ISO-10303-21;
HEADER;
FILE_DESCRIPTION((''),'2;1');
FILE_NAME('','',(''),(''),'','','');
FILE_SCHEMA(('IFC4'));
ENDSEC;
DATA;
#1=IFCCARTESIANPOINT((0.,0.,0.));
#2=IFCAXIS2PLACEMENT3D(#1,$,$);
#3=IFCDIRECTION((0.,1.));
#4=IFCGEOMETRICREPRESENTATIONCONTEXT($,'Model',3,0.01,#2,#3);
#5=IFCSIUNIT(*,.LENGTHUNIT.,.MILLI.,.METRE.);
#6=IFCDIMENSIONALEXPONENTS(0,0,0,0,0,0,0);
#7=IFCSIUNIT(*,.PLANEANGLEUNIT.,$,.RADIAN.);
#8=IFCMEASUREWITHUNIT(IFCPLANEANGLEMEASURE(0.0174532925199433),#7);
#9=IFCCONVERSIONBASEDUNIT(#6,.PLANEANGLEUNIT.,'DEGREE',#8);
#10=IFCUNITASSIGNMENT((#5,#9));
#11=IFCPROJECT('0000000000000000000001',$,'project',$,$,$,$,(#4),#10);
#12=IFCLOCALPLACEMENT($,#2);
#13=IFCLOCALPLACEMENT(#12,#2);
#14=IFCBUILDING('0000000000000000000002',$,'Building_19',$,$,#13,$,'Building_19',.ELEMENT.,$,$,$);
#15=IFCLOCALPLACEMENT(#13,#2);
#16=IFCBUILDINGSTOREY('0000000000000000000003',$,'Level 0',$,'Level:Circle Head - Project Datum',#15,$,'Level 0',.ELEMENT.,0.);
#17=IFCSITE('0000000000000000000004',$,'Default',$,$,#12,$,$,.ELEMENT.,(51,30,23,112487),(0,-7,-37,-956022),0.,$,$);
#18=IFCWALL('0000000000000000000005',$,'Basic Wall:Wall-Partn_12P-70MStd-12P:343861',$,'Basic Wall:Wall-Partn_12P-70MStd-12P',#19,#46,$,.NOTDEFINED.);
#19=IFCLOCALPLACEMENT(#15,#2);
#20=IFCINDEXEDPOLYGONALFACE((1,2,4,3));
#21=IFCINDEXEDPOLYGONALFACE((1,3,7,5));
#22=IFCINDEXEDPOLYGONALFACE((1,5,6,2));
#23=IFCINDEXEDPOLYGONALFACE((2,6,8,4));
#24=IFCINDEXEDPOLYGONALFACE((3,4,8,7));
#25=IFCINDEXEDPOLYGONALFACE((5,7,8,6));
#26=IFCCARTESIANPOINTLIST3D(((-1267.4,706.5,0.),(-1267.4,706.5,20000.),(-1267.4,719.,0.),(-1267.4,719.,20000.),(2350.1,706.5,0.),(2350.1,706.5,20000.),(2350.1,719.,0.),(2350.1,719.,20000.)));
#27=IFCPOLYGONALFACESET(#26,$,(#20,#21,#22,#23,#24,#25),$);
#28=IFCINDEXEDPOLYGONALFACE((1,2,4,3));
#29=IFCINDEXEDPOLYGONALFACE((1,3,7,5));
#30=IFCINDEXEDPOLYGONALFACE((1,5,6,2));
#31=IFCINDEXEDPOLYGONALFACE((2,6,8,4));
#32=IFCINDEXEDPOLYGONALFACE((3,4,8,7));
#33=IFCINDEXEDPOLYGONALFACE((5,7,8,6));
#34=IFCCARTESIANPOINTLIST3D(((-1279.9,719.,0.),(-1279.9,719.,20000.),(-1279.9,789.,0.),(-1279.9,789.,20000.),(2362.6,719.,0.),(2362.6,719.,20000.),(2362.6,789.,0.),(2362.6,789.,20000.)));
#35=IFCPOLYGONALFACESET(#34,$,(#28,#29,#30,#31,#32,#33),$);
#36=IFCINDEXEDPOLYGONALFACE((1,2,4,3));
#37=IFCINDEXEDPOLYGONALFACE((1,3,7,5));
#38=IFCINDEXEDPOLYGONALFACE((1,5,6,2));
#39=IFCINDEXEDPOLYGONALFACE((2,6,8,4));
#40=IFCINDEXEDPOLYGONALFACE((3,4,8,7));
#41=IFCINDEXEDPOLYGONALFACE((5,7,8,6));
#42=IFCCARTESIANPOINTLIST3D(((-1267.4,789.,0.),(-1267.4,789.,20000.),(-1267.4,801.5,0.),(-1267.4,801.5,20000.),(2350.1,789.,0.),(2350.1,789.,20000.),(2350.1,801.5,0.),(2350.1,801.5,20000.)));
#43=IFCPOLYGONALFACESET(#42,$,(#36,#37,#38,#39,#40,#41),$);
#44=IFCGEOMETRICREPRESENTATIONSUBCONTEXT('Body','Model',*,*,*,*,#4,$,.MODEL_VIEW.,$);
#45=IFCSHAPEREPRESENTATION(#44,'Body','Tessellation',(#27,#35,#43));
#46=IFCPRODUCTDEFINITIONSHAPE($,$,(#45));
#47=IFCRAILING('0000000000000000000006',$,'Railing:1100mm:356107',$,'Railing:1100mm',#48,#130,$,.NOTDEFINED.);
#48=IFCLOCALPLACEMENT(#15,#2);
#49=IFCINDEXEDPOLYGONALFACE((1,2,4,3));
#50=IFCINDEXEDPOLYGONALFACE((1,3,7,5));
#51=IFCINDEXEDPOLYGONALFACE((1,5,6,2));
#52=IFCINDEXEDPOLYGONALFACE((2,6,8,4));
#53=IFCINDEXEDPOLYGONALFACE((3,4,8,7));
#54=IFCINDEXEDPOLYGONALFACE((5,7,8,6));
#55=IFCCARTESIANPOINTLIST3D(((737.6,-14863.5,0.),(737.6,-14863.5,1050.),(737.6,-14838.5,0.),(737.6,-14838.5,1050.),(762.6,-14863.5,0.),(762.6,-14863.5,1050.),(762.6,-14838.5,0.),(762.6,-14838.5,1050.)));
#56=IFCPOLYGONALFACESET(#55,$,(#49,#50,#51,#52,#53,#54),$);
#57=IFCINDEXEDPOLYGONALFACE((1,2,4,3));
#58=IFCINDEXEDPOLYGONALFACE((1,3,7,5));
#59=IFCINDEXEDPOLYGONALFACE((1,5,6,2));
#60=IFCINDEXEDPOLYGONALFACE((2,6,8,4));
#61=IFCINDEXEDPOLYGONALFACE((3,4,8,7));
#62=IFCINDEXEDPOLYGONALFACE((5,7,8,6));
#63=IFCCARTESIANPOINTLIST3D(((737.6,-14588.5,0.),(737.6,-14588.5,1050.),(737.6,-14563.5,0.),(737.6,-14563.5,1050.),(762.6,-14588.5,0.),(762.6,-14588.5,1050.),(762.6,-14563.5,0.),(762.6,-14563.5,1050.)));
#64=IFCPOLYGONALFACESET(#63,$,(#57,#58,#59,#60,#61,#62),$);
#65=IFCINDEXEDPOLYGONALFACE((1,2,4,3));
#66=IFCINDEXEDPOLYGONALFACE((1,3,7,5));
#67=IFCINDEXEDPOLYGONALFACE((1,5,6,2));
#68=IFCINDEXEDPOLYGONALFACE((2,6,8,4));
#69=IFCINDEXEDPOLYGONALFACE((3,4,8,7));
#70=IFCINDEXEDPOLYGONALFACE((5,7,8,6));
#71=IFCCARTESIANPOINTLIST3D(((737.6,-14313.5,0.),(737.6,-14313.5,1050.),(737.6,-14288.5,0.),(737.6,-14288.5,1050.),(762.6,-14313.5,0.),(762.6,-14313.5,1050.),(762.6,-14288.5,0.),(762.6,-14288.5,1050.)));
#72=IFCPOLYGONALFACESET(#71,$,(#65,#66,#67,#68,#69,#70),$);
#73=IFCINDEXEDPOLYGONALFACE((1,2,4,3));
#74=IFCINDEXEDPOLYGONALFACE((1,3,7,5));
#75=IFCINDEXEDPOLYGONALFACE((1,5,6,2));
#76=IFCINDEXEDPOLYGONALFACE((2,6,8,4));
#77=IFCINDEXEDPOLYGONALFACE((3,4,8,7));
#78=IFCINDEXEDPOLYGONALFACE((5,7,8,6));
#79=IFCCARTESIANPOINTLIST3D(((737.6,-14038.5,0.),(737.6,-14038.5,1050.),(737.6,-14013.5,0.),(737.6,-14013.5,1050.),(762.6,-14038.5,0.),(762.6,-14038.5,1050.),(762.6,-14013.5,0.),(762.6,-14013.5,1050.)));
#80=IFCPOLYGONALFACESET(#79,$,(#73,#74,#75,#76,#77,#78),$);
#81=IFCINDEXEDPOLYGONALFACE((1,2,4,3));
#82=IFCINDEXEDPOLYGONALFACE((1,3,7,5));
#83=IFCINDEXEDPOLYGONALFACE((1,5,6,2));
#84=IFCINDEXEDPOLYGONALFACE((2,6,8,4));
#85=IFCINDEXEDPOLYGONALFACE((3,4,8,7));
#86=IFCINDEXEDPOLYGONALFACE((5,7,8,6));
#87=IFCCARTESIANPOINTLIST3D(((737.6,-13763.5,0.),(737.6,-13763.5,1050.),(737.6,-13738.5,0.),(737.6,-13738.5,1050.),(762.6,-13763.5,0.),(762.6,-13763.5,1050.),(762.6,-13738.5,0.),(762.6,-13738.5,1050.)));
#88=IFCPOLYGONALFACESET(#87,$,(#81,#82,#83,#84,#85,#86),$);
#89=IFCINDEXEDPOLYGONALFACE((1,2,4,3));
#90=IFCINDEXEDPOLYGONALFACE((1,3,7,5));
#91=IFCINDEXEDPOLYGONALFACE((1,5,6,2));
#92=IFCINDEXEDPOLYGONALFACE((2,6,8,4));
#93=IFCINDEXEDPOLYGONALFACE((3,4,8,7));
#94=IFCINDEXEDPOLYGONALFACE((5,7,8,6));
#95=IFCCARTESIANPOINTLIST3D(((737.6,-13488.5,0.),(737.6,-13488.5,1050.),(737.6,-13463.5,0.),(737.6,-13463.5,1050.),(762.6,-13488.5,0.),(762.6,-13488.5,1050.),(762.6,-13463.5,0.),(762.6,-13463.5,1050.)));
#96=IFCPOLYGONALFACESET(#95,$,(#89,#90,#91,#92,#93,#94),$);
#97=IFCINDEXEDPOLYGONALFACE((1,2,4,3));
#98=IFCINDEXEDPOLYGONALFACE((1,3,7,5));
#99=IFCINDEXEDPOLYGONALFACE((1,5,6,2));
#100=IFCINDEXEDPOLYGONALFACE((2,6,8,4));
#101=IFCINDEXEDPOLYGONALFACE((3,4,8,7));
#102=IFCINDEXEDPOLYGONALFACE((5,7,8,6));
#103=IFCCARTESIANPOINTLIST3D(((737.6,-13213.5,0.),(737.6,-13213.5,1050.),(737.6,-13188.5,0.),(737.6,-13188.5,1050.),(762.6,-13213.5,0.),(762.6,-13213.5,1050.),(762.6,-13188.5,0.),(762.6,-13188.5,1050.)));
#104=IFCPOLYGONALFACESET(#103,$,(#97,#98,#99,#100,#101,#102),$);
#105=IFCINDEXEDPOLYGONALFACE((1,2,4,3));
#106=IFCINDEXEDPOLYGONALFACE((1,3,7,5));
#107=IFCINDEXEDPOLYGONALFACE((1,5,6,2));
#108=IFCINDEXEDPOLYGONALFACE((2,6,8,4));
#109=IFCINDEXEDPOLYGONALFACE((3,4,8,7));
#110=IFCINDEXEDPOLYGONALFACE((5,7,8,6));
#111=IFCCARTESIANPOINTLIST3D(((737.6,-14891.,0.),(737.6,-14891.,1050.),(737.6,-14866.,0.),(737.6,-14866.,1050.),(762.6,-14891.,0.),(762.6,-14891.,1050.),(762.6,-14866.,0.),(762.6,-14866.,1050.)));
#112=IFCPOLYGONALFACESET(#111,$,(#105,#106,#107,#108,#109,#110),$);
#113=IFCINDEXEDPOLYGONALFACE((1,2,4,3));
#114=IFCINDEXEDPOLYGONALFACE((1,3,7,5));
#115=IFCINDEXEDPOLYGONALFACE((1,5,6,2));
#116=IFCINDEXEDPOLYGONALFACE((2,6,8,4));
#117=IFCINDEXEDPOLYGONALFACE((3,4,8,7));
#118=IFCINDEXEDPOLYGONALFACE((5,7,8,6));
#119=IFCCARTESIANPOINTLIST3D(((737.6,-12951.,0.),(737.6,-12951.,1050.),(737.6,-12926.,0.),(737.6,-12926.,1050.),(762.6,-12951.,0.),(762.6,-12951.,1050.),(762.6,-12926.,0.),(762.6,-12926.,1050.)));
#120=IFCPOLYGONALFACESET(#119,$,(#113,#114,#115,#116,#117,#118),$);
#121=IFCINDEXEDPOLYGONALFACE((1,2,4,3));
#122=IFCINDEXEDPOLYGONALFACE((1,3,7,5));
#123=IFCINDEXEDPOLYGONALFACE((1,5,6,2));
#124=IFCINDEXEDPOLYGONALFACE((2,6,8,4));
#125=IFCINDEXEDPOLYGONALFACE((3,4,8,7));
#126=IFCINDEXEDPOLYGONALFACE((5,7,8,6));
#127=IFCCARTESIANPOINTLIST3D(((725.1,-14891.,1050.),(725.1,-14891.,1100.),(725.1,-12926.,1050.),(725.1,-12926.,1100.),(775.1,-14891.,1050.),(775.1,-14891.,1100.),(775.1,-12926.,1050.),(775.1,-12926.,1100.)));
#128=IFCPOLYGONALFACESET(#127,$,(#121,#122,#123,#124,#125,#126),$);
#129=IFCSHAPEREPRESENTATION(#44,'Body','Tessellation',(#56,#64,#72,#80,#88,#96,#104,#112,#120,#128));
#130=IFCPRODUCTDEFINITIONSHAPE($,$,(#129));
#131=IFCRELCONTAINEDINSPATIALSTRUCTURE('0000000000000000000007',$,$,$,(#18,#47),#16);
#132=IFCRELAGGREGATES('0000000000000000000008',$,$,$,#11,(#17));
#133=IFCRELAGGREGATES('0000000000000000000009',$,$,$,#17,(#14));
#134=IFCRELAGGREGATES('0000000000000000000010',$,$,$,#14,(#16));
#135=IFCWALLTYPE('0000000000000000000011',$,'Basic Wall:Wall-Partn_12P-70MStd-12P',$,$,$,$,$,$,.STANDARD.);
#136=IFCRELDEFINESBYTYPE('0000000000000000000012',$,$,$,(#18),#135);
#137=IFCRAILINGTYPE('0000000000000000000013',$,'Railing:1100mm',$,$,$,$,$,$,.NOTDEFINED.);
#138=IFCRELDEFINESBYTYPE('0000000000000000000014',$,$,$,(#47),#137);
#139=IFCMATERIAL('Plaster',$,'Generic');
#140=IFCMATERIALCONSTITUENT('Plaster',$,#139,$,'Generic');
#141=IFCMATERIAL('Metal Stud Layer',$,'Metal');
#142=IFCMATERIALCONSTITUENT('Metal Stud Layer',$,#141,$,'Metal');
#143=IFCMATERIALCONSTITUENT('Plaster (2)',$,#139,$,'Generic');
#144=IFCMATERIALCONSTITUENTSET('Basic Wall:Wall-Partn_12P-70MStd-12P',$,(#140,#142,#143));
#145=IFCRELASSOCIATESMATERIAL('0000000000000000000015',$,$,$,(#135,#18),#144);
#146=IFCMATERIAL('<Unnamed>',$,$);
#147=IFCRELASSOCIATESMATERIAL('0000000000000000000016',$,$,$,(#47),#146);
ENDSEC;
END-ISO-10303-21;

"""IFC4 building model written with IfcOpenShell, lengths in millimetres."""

from ifc_helpers import new_model, entity, si_unit, converted_unit, direction, frame, origin, place, context, subcontext, project, spatial, indexed_curve, outline, extrude, material, constituent, constituent_set, type_object, element, save


model = new_model("IFC4")

# Units and contexts
model_context = context("Model", 3, precision=0.01, world=origin(), true_north=direction((0.0, 1.0)))
body_context = subcontext(model_context, "Body", "Model", "MODEL_VIEW")
ifc_project = project(units=[si_unit("LENGTHUNIT", "METRE", prefix="MILLI"), converted_unit("PLANEANGLEUNIT", "DEGREE", entity("IfcPlaneAngleMeasure", 0.0174532925199433), si_unit("PLANEANGLEUNIT", "RADIAN"), dimensions=[0, 0, 0, 0, 0, 0, 0])], contexts=[model_context])

# Site, building, storey
site_placement = place(None, origin())
site = spatial("IfcSite", under=ifc_project, at=site_placement, Name="Default", CompositionType="ELEMENT", RefLatitude=(51, 30, 23, 112487), RefLongitude=(0, -7, -37, -956022), RefElevation=0.0)
building_placement = place(site_placement, origin())
building = spatial("IfcBuilding", under=site, at=building_placement, Name="Building_19", LongName="Building_19", CompositionType="ELEMENT")
storey_placement = place(building_placement, origin())
storey = spatial("IfcBuildingStorey", under=building, at=storey_placement, Name="Level 0", ObjectType="Level:Circle Head - Project Datum", LongName="Level 0", CompositionType="ELEMENT", Elevation=0.0)

# Shared definitions
ifc_material_1 = material(Name="Plaster", Category="Generic")
ifc_constituent_1 = constituent(ifc_material_1, Name="Plaster", Category="Generic")
ifc_material_2 = material(Name="Metal Stud Layer", Category="Metal")
ifc_constituent_2 = constituent(ifc_material_2, Name="Metal Stud Layer", Category="Metal")
ifc_constituent_3 = constituent(ifc_material_1, Name="Plaster (2)", Category="Generic")
ifc_constituent_set_1 = constituent_set(constituents=[ifc_constituent_1, ifc_constituent_2, ifc_constituent_3], Name="Basic Wall:Wall-Partn_12P-70MStd-12P")
wall_type_1 = type_object("IfcWallType", Name="Basic Wall:Wall-Partn_12P-70MStd-12P", PredefinedType="STANDARD", material=ifc_constituent_set_1)

# Wall
wall_1_placement = place(storey_placement, frame((-1267.4, 754.0, 0.0)))
element("IfcWall", 1, at=wall_1_placement, inside=storey, type_object=wall_type_1, material=ifc_constituent_set_1, Name="Basic Wall:Wall-Partn_12P-70MStd-12P:343861", ObjectType="Basic Wall:Wall-Partn_12P-70MStd-12P", PredefinedType="NOTDEFINED", context=body_context, shape_type="SweptSolid", body=[
    extrude(outline(indexed_curve([(-6.3, -1808.8), (6.2, -1808.8), (6.3, 1808.8), (-6.2, 1808.8), (-6.3, -1808.8)], self_intersect=False)), frame((1808.8, -41.2, 0.0), z_axis=(0.0, 0.0, 1.0), x_axis=(0.0, 1.0, 0.0)), (0.0, 0.0, 1.0), 20000.0),
    extrude(outline(indexed_curve([(-1821.2, -35.0), (1821.2, -35.0), (1821.2, 35.0), (-1821.2, 35.0), (-1821.2, -35.0)], self_intersect=False)), frame((1808.8, 0.0, 0.0)), (0.0, 0.0, 1.0), 20000.0),
    extrude(outline(indexed_curve([(-6.3, -1808.8), (6.2, -1808.8), (6.3, 1808.8), (-6.2, 1808.8), (-6.3, -1808.8)], self_intersect=False)), frame((1808.8, 41.2, 0.0), z_axis=(0.0, 0.0, 1.0), x_axis=(0.0, -1.0, 0.0)), (0.0, 0.0, 1.0), 20000.0),
])

# Railing
ifc_material_3 = material(Name="<Unnamed>")
railing_type = type_object("IfcRailingType", Name="Railing:1100mm", PredefinedType="NOTDEFINED")
railing_placement = place(storey_placement, origin())
element("IfcRailing", 2, at=railing_placement, inside=storey, type_object=railing_type, material=ifc_material_3, Name="Railing:1100mm:356107", ObjectType="Railing:1100mm", PredefinedType="NOTDEFINED", context=body_context, shape_type="SweptSolid", body=[
    extrude(outline(indexed_curve([(-12.5, -12.5), (12.5, -12.5), (12.5, 12.5), (-12.5, 12.5), (-12.5, -12.5)], self_intersect=False)), frame((750.1, -14851.0, 0.0), z_axis=(0.0, 0.0, 1.0), x_axis=(0.0, -1.0, 0.0)), (0.0, 0.0, 1.0), 1050.0),
    extrude(outline(indexed_curve([(-12.5, -12.5), (12.5, -12.5), (12.5, 12.5), (-12.5, 12.5), (-12.5, -12.5)], self_intersect=False)), frame((750.1, -14576.0, 0.0), z_axis=(0.0, 0.0, 1.0), x_axis=(0.0, -1.0, 0.0)), (0.0, 0.0, 1.0), 1050.0),
    extrude(outline(indexed_curve([(-12.5, -12.5), (12.5, -12.5), (12.5, 12.5), (-12.5, 12.5), (-12.5, -12.5)], self_intersect=False)), frame((750.1, -14301.0, 0.0), z_axis=(0.0, 0.0, 1.0), x_axis=(0.0, -1.0, 0.0)), (0.0, 0.0, 1.0), 1050.0),
    extrude(outline(indexed_curve([(-12.5, -12.5), (12.5, -12.5), (12.5, 12.5), (-12.5, 12.5), (-12.5, -12.5)], self_intersect=False)), frame((750.1, -14026.0, 0.0), z_axis=(0.0, 0.0, 1.0), x_axis=(0.0, -1.0, 0.0)), (0.0, 0.0, 1.0), 1050.0),
    extrude(outline(indexed_curve([(-12.5, -12.5), (12.5, -12.5), (12.5, 12.5), (-12.5, 12.5), (-12.5, -12.5)], self_intersect=False)), frame((750.1, -13751.0, 0.0), z_axis=(0.0, 0.0, 1.0), x_axis=(0.0, -1.0, 0.0)), (0.0, 0.0, 1.0), 1050.0),
    extrude(outline(indexed_curve([(-12.5, -12.5), (12.5, -12.5), (12.5, 12.5), (-12.5, 12.5), (-12.5, -12.5)], self_intersect=False)), frame((750.1, -13476.0, 0.0), z_axis=(0.0, 0.0, 1.0), x_axis=(0.0, -1.0, 0.0)), (0.0, 0.0, 1.0), 1050.0),
    extrude(outline(indexed_curve([(-12.5, -12.5), (12.5, -12.5), (12.5, 12.5), (-12.5, 12.5), (-12.5, -12.5)], self_intersect=False)), frame((750.1, -13201.0, 0.0), z_axis=(0.0, 0.0, 1.0), x_axis=(0.0, -1.0, 0.0)), (0.0, 0.0, 1.0), 1050.0),
    extrude(outline(indexed_curve([(-12.5, -12.5), (12.5, -12.5), (12.5, 12.5), (-12.5, 12.5), (-12.5, -12.5)], self_intersect=False)), frame((750.1, -14878.5, 0.0), z_axis=(0.0, 0.0, 1.0), x_axis=(0.0, -1.0, 0.0)), (0.0, 0.0, 1.0), 1050.0),
    extrude(outline(indexed_curve([(-12.5, -12.5), (12.5, -12.5), (12.5, 12.5), (-12.5, 12.5), (-12.5, -12.5)], self_intersect=False)), frame((750.1, -12938.5, 0.0), z_axis=(0.0, 0.0, 1.0), x_axis=(0.0, -1.0, 0.0)), (0.0, 0.0, 1.0), 1050.0),
    extrude(outline(indexed_curve([(-982.5, -25.0), (982.5, -25.0), (982.5, 25.0), (-982.5, 25.0), (-982.5, -25.0)], self_intersect=False)), frame((750.1, -13908.5, 1050.0), z_axis=(0.0, 0.0, 1.0), x_axis=(0.0, -1.0, 0.0)), (0.0, 0.0, 1.0), 50.0),
])

save(model, "model.ifc")
